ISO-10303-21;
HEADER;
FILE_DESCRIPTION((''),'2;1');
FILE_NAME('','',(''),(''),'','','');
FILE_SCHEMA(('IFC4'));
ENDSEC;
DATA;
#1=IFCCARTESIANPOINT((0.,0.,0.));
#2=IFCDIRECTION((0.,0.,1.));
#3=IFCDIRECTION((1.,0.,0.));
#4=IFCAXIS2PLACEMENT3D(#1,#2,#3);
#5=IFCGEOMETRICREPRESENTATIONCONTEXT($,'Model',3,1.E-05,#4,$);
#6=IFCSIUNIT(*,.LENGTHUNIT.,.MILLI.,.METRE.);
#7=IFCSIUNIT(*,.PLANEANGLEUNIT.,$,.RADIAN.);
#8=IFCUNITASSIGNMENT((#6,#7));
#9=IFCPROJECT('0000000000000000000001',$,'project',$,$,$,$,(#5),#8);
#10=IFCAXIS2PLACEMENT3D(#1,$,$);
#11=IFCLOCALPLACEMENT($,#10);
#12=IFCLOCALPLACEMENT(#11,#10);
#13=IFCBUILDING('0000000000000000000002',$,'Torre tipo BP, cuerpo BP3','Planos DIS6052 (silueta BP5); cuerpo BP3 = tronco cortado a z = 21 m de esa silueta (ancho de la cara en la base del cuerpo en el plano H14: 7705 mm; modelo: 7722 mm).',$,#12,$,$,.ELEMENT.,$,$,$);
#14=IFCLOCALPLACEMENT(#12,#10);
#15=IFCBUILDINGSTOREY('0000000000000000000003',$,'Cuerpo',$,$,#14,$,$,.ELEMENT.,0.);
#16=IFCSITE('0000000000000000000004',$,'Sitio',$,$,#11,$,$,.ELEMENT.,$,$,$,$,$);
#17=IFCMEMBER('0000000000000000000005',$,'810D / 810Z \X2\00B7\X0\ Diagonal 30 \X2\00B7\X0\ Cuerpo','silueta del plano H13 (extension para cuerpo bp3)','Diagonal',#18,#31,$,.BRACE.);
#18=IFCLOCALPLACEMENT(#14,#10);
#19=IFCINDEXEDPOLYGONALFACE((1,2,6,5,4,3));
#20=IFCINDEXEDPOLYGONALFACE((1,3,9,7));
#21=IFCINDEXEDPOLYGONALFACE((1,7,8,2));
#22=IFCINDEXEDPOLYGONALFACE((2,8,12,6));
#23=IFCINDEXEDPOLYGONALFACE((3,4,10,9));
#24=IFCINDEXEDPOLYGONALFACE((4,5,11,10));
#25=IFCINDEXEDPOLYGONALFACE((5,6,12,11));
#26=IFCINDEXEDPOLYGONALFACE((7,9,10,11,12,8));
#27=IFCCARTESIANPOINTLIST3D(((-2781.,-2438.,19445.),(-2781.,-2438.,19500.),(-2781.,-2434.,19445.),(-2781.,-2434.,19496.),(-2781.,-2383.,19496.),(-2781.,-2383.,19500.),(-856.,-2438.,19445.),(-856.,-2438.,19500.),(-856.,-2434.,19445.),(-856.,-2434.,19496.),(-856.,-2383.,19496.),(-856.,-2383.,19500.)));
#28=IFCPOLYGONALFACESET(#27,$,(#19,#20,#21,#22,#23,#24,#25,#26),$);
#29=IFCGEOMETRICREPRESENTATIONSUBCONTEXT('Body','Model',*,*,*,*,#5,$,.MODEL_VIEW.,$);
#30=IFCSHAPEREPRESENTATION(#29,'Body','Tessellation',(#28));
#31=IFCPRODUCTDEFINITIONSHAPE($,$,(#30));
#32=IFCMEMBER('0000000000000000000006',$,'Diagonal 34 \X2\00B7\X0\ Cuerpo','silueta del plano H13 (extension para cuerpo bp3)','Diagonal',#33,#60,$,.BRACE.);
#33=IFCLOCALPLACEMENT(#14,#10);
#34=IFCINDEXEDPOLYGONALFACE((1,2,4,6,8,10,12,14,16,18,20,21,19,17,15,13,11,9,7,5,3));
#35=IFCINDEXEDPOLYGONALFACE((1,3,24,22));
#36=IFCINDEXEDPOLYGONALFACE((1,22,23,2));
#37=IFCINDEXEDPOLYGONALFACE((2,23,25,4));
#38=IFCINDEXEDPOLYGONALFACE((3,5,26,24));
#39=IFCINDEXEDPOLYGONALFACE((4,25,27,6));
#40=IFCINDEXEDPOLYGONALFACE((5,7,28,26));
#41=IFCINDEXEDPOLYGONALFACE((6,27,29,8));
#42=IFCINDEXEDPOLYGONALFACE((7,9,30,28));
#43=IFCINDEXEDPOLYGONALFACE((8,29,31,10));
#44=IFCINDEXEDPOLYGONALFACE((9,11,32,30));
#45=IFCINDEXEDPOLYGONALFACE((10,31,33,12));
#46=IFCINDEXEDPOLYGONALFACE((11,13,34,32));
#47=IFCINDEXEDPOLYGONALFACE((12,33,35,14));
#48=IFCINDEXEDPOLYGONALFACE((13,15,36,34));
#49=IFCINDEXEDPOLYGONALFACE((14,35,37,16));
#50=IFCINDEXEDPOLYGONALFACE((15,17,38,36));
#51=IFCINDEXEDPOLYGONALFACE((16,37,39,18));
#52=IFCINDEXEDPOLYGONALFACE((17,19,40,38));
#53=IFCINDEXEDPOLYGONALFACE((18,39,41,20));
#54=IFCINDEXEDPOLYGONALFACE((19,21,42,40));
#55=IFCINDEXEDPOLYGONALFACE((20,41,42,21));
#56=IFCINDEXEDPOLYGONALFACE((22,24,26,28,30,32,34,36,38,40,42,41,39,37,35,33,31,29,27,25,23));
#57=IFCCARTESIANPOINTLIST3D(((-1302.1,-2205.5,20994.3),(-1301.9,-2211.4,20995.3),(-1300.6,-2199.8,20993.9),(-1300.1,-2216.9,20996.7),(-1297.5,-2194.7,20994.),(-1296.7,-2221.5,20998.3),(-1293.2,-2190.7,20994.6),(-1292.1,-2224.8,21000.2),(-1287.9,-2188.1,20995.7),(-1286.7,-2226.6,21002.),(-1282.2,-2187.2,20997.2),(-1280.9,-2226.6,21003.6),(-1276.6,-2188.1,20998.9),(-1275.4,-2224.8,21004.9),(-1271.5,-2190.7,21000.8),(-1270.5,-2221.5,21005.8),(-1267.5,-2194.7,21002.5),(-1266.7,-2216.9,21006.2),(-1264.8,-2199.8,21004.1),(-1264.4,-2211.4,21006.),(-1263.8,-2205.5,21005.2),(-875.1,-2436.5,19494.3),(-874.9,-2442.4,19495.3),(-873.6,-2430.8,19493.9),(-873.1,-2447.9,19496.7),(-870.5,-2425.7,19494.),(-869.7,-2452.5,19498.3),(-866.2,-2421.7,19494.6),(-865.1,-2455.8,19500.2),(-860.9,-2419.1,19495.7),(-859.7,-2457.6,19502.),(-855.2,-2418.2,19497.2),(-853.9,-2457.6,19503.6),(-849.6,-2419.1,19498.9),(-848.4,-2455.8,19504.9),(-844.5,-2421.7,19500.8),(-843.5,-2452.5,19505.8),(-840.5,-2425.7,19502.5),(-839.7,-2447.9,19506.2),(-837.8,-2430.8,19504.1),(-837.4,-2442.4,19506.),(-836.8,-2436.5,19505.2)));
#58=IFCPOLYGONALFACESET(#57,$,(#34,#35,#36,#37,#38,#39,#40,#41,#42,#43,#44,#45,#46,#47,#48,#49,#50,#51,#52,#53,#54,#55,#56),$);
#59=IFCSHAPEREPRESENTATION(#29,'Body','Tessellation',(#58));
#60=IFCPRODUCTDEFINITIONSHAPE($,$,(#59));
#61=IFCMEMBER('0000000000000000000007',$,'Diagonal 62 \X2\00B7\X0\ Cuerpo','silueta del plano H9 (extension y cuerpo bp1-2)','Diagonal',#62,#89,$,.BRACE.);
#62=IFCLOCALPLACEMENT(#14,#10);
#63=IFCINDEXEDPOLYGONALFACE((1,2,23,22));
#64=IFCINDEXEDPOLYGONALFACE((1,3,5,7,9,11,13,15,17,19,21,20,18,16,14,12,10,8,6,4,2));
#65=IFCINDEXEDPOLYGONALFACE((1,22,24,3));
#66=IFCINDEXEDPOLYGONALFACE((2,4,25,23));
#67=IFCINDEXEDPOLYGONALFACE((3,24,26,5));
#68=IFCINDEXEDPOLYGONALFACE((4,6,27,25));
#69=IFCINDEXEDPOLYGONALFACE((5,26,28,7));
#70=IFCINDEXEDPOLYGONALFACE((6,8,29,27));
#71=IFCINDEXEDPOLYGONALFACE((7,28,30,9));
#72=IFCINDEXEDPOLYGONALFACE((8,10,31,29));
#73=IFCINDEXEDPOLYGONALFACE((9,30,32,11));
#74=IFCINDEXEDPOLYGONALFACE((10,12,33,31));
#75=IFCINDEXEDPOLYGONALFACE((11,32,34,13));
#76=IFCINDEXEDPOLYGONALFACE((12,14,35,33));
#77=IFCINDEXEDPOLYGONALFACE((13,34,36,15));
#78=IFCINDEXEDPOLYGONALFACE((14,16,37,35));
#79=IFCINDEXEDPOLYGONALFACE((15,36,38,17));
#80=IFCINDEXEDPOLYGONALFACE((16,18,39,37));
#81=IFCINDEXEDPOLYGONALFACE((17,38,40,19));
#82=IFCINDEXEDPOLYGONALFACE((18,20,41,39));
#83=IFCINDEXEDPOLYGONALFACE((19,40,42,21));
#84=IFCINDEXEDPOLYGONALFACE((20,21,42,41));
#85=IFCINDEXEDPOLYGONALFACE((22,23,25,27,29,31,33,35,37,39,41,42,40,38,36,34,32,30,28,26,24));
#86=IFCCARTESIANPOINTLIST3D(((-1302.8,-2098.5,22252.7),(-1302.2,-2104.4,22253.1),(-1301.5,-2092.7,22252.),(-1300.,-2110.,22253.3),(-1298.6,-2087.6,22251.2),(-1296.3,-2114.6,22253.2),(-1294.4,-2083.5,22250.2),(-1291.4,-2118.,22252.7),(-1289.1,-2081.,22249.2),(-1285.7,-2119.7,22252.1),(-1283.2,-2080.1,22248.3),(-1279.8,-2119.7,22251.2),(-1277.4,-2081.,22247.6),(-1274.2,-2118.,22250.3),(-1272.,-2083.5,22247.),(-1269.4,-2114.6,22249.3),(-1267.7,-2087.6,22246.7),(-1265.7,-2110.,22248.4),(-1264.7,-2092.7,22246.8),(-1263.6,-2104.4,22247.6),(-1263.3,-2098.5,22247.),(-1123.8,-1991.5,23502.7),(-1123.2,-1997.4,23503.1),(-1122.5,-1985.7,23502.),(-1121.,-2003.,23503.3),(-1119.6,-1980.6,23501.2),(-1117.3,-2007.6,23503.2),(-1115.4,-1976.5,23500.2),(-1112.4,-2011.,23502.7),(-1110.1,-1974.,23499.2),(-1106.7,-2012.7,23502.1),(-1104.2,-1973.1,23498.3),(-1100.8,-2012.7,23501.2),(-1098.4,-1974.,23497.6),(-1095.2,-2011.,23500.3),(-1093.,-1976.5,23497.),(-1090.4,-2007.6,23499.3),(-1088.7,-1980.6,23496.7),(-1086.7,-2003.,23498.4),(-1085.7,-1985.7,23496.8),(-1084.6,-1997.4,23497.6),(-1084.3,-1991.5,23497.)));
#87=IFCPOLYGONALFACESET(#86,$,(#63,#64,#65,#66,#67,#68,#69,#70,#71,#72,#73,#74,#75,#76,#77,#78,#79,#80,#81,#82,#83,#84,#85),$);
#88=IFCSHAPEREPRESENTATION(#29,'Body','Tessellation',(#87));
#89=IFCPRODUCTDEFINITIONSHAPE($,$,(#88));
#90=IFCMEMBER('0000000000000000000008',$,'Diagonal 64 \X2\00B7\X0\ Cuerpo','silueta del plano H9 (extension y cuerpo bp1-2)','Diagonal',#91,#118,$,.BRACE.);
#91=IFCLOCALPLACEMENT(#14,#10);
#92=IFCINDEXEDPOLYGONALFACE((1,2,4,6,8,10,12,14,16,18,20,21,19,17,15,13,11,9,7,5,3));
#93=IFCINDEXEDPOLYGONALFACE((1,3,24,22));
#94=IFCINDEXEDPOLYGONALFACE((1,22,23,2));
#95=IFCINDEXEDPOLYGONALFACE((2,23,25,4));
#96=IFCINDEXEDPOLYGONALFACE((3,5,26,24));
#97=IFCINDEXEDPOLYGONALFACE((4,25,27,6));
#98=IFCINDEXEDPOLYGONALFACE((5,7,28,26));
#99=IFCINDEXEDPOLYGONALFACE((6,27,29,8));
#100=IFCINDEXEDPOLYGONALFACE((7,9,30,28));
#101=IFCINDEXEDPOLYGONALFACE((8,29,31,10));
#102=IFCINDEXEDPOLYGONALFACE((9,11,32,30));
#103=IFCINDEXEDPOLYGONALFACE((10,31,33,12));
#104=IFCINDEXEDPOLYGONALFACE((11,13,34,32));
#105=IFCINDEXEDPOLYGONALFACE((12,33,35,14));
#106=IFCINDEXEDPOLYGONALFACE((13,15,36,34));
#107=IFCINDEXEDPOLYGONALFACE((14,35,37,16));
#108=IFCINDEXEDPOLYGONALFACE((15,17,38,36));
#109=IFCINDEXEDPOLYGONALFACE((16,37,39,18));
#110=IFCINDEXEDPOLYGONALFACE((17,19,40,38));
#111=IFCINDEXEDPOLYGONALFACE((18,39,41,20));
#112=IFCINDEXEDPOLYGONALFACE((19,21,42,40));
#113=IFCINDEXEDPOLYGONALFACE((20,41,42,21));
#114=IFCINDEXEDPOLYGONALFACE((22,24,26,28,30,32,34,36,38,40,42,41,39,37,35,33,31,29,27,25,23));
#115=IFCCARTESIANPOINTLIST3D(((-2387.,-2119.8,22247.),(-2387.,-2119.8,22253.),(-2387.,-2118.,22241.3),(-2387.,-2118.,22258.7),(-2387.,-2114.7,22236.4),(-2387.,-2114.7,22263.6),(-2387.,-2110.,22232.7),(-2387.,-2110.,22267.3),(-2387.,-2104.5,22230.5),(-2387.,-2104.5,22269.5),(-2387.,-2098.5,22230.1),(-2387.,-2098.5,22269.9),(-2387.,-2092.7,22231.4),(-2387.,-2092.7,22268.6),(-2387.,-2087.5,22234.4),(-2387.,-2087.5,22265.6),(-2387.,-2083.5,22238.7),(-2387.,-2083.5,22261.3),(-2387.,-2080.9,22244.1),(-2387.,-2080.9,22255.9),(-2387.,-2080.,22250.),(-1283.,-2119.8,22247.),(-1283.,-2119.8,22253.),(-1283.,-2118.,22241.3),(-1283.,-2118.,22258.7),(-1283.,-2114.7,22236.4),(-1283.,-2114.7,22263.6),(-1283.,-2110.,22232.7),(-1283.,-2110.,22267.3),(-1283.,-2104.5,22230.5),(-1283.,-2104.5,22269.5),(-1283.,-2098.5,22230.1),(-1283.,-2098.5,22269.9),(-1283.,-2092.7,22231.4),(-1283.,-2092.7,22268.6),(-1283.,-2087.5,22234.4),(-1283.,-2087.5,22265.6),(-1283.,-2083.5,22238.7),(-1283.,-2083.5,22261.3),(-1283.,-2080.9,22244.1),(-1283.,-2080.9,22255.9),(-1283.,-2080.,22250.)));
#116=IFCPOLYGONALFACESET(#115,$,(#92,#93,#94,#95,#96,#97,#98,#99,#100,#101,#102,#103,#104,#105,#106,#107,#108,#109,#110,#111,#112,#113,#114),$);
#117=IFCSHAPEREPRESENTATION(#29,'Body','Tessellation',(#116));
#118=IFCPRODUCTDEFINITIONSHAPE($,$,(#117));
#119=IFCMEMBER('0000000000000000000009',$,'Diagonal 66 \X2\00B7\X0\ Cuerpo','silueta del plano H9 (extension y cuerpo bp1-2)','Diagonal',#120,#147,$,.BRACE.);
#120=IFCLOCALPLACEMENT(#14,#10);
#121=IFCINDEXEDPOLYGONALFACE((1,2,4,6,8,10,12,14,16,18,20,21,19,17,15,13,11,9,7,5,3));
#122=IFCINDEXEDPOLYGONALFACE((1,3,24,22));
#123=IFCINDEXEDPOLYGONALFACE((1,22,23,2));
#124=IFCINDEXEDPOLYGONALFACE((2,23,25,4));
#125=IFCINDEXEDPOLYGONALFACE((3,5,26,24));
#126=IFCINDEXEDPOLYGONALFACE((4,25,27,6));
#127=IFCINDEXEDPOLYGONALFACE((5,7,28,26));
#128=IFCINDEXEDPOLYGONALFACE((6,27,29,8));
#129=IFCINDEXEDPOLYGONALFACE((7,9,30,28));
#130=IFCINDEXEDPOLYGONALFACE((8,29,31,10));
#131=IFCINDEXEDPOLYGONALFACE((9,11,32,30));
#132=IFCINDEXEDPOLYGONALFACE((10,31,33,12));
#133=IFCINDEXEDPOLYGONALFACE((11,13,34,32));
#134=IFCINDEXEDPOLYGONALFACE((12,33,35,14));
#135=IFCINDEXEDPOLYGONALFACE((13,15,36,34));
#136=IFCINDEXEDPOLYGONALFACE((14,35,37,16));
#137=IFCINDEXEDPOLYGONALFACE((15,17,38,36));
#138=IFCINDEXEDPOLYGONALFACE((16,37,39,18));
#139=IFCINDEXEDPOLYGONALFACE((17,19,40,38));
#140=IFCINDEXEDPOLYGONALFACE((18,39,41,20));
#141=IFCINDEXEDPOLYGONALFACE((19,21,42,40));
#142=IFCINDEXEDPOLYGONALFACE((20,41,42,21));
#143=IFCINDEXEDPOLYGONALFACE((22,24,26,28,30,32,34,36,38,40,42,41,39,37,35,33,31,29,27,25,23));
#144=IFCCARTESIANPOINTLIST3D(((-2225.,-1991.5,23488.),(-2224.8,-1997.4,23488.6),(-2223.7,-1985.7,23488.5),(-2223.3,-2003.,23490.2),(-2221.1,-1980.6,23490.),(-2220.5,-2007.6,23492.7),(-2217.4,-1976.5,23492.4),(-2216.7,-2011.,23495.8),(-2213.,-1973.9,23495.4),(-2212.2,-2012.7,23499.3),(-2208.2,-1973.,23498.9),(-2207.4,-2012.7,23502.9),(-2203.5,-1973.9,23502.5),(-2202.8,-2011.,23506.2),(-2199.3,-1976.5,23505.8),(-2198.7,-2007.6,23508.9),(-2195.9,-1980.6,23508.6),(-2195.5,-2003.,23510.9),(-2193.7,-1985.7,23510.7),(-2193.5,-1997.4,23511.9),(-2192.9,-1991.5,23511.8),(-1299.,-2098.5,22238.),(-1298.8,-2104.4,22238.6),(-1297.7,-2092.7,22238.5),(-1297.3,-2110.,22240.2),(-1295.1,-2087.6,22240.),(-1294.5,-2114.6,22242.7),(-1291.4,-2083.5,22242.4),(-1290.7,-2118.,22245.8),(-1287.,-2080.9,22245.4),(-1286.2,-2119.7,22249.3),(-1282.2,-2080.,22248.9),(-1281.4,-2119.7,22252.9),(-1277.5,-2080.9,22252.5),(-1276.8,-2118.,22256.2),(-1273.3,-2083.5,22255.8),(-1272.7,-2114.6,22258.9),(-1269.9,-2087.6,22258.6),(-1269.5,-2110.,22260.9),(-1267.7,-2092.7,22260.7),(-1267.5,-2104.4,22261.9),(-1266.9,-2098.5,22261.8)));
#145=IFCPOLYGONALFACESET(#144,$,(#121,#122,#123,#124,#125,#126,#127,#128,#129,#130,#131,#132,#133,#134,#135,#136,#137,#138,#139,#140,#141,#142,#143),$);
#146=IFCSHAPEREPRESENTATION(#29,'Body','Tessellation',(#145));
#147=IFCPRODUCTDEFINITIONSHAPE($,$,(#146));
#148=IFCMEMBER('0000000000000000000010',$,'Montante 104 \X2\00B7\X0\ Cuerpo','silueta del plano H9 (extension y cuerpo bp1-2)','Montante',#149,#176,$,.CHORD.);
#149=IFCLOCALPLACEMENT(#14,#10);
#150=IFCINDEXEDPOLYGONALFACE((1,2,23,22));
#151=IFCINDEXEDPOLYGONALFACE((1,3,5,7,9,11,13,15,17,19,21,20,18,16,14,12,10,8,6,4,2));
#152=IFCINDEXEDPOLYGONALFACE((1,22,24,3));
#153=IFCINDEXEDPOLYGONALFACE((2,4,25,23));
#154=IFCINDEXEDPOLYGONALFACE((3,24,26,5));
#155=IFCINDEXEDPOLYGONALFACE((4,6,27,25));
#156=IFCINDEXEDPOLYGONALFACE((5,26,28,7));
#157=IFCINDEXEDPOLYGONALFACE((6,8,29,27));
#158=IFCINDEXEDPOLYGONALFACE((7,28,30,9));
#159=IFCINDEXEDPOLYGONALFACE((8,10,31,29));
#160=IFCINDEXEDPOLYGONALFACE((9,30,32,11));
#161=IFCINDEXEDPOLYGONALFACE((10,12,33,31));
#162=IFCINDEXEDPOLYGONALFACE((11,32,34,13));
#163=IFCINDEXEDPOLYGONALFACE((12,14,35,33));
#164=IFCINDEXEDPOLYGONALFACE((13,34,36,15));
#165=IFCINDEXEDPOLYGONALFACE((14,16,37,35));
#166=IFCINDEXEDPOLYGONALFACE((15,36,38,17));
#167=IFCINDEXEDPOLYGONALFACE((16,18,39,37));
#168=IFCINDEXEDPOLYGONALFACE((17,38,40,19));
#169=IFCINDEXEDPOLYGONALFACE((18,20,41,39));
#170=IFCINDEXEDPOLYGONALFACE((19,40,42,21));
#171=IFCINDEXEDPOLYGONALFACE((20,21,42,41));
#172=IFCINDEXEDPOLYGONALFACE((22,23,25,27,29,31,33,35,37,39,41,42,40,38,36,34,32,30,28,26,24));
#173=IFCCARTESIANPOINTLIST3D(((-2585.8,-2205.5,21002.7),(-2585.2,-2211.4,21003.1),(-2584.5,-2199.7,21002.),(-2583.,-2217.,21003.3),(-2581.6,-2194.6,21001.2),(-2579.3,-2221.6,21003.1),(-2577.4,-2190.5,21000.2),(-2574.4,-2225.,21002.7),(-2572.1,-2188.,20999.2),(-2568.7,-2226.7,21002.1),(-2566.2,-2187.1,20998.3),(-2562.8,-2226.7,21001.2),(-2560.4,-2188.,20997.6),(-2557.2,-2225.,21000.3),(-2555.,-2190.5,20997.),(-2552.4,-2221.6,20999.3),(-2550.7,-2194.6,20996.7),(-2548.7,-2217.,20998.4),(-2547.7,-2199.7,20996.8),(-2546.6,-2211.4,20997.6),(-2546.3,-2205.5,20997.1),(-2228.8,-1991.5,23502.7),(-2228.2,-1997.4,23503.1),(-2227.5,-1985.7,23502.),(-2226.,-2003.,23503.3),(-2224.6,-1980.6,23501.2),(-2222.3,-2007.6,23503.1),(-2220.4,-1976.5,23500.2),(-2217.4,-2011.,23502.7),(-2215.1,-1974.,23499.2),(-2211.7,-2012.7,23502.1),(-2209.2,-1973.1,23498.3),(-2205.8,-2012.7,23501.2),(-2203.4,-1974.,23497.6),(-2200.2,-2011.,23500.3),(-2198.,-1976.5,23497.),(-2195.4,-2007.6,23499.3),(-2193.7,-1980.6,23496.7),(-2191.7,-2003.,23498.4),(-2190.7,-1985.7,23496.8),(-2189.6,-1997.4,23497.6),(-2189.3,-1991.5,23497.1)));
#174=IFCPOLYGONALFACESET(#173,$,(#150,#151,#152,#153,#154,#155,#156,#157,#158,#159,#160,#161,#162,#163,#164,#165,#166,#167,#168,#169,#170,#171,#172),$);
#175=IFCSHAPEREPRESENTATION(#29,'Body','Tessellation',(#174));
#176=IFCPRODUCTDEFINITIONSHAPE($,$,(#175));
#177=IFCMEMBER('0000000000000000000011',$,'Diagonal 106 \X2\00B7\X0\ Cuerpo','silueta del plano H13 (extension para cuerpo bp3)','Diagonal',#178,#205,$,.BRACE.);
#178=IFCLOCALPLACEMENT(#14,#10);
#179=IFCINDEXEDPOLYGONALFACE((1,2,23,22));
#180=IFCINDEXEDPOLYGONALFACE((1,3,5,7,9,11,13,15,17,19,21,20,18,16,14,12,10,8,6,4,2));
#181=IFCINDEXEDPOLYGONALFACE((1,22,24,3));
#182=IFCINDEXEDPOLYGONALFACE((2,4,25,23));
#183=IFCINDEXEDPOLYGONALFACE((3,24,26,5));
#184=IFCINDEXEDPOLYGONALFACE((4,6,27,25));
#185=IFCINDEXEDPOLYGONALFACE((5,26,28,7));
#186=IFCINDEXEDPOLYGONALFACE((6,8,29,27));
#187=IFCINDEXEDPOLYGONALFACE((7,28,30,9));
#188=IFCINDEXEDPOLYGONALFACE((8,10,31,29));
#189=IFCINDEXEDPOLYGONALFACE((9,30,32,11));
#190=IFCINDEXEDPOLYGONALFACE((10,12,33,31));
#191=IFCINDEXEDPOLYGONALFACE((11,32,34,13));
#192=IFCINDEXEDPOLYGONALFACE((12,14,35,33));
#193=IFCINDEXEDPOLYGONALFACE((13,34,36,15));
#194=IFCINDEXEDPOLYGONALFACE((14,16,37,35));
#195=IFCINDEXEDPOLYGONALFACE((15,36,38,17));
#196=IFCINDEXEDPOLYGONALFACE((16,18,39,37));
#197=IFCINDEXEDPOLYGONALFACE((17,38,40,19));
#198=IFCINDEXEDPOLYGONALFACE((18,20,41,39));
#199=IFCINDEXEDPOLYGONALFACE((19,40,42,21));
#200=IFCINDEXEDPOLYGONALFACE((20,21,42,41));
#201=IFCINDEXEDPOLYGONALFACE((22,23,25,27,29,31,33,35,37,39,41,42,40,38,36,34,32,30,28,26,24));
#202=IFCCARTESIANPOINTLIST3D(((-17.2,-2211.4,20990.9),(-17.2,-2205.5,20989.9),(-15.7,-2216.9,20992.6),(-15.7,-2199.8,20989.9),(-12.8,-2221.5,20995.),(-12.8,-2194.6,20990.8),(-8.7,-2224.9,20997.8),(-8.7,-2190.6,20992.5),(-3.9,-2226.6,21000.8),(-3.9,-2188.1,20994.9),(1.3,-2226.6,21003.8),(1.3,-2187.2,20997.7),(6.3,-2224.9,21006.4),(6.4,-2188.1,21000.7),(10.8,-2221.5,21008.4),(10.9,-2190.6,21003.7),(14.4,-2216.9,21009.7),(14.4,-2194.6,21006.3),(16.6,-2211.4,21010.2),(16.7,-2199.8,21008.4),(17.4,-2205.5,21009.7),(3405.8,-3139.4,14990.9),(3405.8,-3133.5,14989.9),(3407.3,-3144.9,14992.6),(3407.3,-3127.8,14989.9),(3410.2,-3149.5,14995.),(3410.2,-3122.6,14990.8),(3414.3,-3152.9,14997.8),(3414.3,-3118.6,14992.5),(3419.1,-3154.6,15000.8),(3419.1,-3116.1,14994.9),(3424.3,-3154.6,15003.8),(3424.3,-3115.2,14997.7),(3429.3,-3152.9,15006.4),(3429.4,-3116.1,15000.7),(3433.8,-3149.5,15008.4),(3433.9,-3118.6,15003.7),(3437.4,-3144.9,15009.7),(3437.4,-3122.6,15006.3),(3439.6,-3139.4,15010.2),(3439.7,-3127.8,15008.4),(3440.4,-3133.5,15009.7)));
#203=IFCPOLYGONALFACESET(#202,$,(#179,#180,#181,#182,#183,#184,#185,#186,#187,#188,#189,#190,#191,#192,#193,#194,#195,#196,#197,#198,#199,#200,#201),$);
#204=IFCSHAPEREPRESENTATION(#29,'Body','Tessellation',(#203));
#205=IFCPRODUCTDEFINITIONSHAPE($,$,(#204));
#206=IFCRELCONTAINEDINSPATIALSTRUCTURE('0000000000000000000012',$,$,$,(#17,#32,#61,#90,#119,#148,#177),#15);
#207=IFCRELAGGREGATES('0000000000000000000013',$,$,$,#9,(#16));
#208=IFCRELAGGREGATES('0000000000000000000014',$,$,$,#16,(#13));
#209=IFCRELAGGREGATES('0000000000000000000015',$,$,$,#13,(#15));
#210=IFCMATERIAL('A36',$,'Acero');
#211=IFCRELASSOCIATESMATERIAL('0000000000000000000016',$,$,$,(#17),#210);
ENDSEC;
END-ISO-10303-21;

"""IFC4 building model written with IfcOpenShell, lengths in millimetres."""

from ifc_helpers import new_model, si_unit, frame, frame_2d, origin, origin_with_axes, place, context, subcontext, project, spatial, circle, l_section, extrude, material, element, save


model = new_model("IFC4")

# Units and contexts
model_context = context("Model", 3, precision=1e-05, world=origin_with_axes())
body_context = subcontext(model_context, "Body", "Model", "MODEL_VIEW")
ifc_project = project(units=[si_unit("LENGTHUNIT", "METRE", prefix="MILLI"), si_unit("PLANEANGLEUNIT", "RADIAN")], contexts=[model_context])

# Site, building, storey
site_placement = place(None, origin())
site = spatial("IfcSite", under=ifc_project, at=site_placement, Name="Sitio", CompositionType="ELEMENT")
building_placement = place(site_placement, origin())
building = spatial("IfcBuilding", under=site, at=building_placement, Name="Torre tipo BP, cuerpo BP3", Description="Planos DIS6052 (silueta BP5); cuerpo BP3 = tronco cortado a z = 21 m de esa silueta (ancho de la cara en la base del cuerpo en el plano H14: 7705 mm; modelo: 7722 mm).", CompositionType="ELEMENT")
storey_placement = place(building_placement, origin())
storey = spatial("IfcBuildingStorey", under=building, at=storey_placement, Name="Cuerpo", CompositionType="ELEMENT", Elevation=0.0)

# Members
ifc_material_1 = material(Name="A36", Category="Acero")
member_1_placement = place(storey_placement, frame((-856.0, -2438.0, 19500.0), z_axis=(-1.0, 0.0, 0.0), x_axis=(0.0, 1.0, 0.0)))
element("IfcMember", 1, at=member_1_placement, inside=storey, material=ifc_material_1, Name="810D / 810Z · Diagonal 30 · Cuerpo", Description="silueta del plano H13 (extension para cuerpo bp3)", ObjectType="Diagonal", PredefinedType="BRACE", context=body_context, shape_type="SweptSolid", body=[
    extrude(l_section(Depth=55.0, Width=55.0, Thickness=4.0, at=frame_2d((27.5, 27.5))), None, (0.0, 0.0, 1.0), 1925.0),
])
member_2_placement = place(storey_placement, frame((-856.0, -2438.0, 19500.0), z_axis=(-0.270835, 0.146517, 0.95141), x_axis=(0.040115, 0.989208, -0.140919)))
element("IfcMember", 2, at=member_2_placement, inside=storey, Name="Diagonal 34 · Cuerpo", Description="silueta del plano H13 (extension para cuerpo bp3)", ObjectType="Diagonal", PredefinedType="BRACE", context=body_context, shape_type="SweptSolid", body=[
    extrude(circle(Radius=20.0), None, (0.0, 0.0, 1.0), 1576.6),
])
member_3_placement = place(storey_placement, frame((-1104.0, -1993.0, 23500.0), z_axis=(-0.141248, -0.084433, -0.986367), x_axis=(-0.011969, 0.996429, -0.08358)))
element("IfcMember", 3, at=member_3_placement, inside=storey, Name="Diagonal 62 · Cuerpo", Description="silueta del plano H9 (extension y cuerpo bp1-2)", ObjectType="Diagonal", PredefinedType="BRACE", context=body_context, shape_type="SweptSolid", body=[
    extrude(circle(Radius=20.0), None, (0.0, 0.0, 1.0), 1267.3),
])
member_4_placement = place(storey_placement, frame((-1283.0, -2100.0, 22250.0), z_axis=(-1.0, 0.0, 0.0), x_axis=(0.0, 1.0, 0.0)))
element("IfcMember", 4, at=member_4_placement, inside=storey, Name="Diagonal 64 · Cuerpo", Description="silueta del plano H9 (extension y cuerpo bp1-2)", ObjectType="Diagonal", PredefinedType="BRACE", context=body_context, shape_type="SweptSolid", body=[
    extrude(circle(Radius=20.0), None, (0.0, 0.0, 1.0), 1104.0),
])
member_5_placement = place(storey_placement, frame((-1283.0, -2100.0, 22250.0), z_axis=(-0.593855, 0.06862, 0.80164), x_axis=(0.040847, 0.997643, -0.055139)))
element("IfcMember", 5, at=member_5_placement, inside=storey, Name="Diagonal 66 · Cuerpo", Description="silueta del plano H9 (extension y cuerpo bp1-2)", ObjectType="Diagonal", PredefinedType="BRACE", context=body_context, shape_type="SweptSolid", body=[
    extrude(circle(Radius=20.0), None, (0.0, 0.0, 1.0), 1559.3),
])
member_6_placement = place(storey_placement, frame((-2209.0, -1993.0, 23500.0), z_axis=(-0.140861, -0.084438, -0.986422), x_axis=(-0.011937, 0.996429, -0.08359)))
element("IfcMember", 6, at=member_6_placement, inside=storey, Name="Montante 104 · Cuerpo", Description="silueta del plano H9 (extension y cuerpo bp1-2)", ObjectType="Montante", PredefinedType="CHORD", context=body_context, shape_type="SweptSolid", body=[
    extrude(circle(Radius=20.0), None, (0.0, 0.0, 1.0), 2534.4),
])
member_7_placement = place(storey_placement, frame((0.0, -2207.0, 21000.0), z_axis=(0.491119, -0.133146, -0.860857), x_axis=(0.065978, 0.991096, -0.115649)))
element("IfcMember", 7, at=member_7_placement, inside=storey, Name="Diagonal 106 · Cuerpo", Description="silueta del plano H13 (extension para cuerpo bp3)", ObjectType="Diagonal", PredefinedType="BRACE", context=body_context, shape_type="SweptSolid", body=[
    extrude(circle(Radius=20.0), None, (0.0, 0.0, 1.0), 6969.8),
])

save(model, "model.ifc")
